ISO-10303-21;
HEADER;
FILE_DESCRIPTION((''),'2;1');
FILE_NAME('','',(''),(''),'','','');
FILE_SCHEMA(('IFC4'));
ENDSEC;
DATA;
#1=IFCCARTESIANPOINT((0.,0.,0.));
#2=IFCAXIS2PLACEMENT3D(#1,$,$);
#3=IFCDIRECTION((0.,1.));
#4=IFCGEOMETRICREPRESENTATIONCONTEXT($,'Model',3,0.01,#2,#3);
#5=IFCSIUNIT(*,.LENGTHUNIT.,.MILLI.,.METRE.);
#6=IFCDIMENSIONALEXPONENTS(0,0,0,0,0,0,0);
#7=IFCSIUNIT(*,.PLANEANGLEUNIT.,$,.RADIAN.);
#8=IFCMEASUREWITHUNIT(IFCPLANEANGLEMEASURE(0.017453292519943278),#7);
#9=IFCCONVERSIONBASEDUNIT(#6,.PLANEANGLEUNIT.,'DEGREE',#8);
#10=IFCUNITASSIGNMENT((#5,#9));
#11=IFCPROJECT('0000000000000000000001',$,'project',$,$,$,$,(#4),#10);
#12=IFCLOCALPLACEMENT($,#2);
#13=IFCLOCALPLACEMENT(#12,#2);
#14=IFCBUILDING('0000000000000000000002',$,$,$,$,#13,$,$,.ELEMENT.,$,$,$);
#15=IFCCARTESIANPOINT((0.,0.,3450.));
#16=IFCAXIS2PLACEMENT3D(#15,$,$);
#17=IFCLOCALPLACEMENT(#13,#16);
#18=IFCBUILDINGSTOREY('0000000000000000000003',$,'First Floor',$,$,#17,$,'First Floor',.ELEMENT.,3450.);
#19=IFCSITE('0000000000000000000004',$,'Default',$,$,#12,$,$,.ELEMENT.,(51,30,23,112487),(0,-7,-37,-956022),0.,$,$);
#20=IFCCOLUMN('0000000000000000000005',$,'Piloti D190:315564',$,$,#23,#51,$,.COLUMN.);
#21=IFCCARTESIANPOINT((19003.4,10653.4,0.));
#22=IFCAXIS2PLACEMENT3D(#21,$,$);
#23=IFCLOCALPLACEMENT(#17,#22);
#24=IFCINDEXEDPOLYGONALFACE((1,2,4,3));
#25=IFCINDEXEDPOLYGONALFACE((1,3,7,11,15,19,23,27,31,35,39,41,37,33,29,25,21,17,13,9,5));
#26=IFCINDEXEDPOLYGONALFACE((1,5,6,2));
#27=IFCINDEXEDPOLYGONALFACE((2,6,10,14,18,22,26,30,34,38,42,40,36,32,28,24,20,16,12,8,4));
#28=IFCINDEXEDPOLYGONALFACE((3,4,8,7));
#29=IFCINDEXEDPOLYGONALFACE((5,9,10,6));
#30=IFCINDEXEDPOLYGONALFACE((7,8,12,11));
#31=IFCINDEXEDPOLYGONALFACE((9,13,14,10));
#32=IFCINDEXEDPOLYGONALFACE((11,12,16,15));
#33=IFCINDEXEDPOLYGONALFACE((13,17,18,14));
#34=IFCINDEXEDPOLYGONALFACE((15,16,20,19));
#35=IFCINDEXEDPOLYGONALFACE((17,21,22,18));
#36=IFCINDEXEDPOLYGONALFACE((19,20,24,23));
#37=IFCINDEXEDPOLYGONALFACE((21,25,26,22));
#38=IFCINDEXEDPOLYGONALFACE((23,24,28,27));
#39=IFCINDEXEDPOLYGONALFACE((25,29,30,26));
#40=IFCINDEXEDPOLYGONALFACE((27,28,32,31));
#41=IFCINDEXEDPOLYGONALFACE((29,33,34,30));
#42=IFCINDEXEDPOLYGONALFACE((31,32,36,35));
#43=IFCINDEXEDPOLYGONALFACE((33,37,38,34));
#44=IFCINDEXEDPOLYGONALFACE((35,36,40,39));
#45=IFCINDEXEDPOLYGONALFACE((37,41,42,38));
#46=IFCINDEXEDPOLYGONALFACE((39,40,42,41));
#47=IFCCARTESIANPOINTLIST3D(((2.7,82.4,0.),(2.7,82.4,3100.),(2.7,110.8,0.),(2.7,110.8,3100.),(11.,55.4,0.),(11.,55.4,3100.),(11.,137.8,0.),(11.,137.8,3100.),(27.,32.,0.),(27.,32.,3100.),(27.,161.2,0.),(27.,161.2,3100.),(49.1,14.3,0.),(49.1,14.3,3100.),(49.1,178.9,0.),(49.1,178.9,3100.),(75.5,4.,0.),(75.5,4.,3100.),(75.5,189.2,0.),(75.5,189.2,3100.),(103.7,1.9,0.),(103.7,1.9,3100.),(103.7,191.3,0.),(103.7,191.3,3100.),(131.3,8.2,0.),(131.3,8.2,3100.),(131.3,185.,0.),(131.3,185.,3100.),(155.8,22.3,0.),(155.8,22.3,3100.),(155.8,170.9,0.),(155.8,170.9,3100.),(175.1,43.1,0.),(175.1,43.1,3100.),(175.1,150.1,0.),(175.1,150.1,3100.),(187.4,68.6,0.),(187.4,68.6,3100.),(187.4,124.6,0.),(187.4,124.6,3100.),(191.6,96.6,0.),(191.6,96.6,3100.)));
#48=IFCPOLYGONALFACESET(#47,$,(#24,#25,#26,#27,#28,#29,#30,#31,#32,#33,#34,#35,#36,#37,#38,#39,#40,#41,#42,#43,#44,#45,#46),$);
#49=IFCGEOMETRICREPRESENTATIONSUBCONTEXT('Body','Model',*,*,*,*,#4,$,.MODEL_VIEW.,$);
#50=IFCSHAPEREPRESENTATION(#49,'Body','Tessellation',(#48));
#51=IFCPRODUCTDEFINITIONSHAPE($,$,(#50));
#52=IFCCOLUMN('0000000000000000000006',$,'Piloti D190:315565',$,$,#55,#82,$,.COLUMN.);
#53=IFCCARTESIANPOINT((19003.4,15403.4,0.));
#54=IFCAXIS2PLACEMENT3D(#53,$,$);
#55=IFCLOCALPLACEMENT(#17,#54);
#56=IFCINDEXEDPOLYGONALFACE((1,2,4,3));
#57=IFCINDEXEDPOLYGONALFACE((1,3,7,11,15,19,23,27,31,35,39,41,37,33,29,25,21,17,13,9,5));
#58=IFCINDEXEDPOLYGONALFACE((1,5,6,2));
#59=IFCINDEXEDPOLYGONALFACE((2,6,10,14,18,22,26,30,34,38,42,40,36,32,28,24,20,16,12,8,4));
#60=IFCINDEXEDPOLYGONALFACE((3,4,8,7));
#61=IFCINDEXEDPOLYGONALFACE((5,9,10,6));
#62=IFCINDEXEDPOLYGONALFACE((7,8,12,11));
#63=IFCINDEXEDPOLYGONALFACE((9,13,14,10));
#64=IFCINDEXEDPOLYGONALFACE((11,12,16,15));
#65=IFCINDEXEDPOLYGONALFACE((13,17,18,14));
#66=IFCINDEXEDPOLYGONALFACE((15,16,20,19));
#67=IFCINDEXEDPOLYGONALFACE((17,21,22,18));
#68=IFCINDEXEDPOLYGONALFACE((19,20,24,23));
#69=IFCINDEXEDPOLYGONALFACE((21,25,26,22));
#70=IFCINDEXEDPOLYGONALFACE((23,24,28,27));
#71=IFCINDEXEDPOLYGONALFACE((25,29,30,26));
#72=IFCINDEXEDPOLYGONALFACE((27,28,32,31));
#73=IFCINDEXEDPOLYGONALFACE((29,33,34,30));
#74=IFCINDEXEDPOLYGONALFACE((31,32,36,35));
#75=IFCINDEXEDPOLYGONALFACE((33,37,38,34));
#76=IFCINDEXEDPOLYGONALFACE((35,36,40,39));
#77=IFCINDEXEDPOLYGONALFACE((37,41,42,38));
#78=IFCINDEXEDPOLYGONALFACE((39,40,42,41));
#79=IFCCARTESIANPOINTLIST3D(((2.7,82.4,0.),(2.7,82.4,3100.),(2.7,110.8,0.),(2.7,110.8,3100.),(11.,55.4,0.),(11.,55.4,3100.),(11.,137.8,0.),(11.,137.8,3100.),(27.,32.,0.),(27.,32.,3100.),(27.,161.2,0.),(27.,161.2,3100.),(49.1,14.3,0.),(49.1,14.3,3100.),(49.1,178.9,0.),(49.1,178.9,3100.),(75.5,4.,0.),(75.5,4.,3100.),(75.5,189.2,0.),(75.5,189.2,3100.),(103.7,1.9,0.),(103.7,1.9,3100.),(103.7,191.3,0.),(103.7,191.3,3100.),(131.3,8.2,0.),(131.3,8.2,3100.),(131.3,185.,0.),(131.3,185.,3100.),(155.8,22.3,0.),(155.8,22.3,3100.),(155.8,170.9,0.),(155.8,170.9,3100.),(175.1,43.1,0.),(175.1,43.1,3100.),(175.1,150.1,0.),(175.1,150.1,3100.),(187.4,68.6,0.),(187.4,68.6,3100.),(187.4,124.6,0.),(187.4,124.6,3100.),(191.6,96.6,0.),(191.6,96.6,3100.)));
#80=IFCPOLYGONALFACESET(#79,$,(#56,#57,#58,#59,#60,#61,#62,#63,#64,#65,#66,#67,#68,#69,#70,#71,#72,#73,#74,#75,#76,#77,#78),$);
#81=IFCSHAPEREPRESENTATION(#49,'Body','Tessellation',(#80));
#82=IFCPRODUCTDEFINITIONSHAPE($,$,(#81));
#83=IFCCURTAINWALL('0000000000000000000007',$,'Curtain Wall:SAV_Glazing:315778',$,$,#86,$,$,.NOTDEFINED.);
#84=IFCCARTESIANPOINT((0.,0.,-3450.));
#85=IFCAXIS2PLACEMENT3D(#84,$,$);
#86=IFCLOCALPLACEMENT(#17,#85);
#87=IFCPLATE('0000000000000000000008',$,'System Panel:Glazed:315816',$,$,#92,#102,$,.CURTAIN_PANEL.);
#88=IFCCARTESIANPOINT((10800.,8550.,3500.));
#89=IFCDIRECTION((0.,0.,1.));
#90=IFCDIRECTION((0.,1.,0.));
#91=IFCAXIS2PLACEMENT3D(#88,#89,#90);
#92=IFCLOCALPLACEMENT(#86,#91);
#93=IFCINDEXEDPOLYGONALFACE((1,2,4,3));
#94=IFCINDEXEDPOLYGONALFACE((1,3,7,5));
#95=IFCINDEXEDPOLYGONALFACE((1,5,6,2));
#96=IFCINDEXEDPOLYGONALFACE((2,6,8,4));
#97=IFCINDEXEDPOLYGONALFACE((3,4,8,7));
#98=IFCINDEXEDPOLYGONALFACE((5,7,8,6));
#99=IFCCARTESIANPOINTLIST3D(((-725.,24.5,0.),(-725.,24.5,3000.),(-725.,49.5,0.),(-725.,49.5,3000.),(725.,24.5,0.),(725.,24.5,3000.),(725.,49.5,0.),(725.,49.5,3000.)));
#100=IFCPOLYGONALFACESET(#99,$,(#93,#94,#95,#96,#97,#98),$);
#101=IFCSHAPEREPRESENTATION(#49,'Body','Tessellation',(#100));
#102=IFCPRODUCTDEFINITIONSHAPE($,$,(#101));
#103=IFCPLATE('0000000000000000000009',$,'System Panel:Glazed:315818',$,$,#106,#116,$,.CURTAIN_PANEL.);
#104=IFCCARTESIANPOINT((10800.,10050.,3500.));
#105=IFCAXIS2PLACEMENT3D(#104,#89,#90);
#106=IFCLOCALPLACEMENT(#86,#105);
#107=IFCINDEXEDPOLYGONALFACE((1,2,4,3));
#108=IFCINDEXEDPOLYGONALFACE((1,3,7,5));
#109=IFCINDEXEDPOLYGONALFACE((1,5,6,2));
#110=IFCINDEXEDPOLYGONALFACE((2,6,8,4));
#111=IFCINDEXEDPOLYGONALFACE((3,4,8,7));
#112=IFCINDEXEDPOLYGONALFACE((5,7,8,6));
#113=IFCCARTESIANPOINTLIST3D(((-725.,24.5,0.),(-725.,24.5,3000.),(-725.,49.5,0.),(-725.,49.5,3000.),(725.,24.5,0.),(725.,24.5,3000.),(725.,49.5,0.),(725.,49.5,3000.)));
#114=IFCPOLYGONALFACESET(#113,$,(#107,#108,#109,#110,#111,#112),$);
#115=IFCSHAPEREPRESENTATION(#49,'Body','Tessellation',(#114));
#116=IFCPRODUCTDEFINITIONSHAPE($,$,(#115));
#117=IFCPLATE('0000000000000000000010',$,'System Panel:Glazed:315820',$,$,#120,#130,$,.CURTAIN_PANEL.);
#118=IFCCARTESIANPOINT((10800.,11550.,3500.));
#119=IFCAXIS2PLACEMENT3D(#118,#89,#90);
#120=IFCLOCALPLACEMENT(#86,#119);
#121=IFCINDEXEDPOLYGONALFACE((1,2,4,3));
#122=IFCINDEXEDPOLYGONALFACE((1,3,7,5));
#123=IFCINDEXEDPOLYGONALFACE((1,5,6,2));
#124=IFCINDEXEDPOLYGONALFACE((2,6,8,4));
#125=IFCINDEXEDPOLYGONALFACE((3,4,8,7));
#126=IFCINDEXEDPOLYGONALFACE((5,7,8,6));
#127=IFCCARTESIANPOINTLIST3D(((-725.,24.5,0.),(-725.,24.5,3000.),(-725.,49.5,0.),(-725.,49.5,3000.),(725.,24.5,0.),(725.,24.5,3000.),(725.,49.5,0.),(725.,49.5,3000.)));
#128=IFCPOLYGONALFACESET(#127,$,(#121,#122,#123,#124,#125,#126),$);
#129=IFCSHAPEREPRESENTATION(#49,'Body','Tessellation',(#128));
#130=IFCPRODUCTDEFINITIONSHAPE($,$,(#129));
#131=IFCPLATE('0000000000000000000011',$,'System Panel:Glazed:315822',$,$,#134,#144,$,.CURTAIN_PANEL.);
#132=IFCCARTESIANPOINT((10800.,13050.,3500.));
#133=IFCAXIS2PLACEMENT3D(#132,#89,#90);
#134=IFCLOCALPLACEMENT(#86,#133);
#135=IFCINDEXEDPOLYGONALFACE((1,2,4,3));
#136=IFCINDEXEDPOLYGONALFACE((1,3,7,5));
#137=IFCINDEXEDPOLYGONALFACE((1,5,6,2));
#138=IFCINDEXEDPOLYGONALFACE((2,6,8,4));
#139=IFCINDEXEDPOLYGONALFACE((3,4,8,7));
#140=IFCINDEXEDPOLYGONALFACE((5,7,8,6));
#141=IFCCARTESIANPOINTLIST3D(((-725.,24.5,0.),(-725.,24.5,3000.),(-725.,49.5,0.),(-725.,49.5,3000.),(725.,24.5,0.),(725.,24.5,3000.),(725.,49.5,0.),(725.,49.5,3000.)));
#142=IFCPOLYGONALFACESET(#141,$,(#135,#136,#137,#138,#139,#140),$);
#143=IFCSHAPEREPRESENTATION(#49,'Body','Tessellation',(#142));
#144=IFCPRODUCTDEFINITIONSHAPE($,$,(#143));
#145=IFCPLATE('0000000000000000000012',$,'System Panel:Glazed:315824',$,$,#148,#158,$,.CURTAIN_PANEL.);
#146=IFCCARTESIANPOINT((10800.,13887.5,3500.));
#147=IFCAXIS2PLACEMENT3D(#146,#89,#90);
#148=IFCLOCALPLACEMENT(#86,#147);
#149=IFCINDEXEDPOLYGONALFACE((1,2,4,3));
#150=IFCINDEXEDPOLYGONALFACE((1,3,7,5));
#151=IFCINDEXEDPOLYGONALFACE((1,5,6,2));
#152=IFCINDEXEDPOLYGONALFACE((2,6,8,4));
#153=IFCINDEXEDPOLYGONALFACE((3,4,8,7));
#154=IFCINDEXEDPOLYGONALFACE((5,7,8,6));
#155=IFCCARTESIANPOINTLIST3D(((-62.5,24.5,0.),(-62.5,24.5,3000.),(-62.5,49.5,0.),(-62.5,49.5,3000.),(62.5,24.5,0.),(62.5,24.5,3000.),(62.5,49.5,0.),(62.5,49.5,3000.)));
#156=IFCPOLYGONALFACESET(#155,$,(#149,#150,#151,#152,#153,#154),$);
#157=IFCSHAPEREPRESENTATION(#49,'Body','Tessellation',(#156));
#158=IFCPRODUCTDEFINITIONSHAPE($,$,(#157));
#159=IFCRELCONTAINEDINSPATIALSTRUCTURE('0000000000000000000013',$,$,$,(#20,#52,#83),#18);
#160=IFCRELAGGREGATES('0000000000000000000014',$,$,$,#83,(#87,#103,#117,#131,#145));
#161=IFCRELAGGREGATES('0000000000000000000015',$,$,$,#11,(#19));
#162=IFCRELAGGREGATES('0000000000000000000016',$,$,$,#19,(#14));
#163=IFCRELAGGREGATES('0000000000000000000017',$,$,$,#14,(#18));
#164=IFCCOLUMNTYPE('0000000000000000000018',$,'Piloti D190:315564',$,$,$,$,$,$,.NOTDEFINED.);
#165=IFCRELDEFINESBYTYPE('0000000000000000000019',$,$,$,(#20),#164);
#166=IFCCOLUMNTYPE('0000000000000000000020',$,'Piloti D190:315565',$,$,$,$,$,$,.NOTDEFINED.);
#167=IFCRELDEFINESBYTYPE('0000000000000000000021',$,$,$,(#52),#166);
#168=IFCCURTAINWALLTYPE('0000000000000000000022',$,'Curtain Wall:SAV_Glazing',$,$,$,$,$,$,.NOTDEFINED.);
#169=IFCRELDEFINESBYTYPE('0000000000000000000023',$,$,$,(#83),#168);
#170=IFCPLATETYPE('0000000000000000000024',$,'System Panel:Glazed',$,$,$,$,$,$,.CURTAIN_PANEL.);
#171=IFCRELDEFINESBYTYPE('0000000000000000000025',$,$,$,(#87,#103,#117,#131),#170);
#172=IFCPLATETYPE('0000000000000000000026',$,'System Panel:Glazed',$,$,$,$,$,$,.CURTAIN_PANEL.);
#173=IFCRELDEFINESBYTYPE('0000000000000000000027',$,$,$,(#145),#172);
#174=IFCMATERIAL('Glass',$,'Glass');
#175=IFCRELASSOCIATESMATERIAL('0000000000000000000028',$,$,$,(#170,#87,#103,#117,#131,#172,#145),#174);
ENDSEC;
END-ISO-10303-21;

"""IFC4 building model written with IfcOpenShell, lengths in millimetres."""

from ifc_helpers import new_model, entity, si_unit, converted_unit, direction, frame, frame_2d, origin, origin_2d_with_axis, place, context, subcontext, project, spatial, rectangle, circle, extrude, source, transform, mapped, material, type_object, type_shapes, element, aggregate, save


model = new_model("IFC4")

# Units and contexts
model_context = context("Model", 3, precision=0.01, world=origin(), true_north=direction((0.0, 1.0)))
body_context = subcontext(model_context, "Body", "Model", "MODEL_VIEW")
ifc_project = project(units=[si_unit("LENGTHUNIT", "METRE", prefix="MILLI"), converted_unit("PLANEANGLEUNIT", "DEGREE", entity("IfcPlaneAngleMeasure", 0.017453292519943278), si_unit("PLANEANGLEUNIT", "RADIAN"), dimensions=[0, 0, 0, 0, 0, 0, 0])], contexts=[model_context])

# Site, building, storey
site_placement = place(None, origin())
site = spatial("IfcSite", under=ifc_project, at=site_placement, Name="Default", CompositionType="ELEMENT", RefLatitude=(51, 30, 23, 112487), RefLongitude=(0, -7, -37, -956022), RefElevation=0.0)
building_placement = place(site_placement, origin())
building = spatial("IfcBuilding", under=site, at=building_placement, CompositionType="ELEMENT")
storey_placement = place(building_placement, frame((0.0, 0.0, 3450.0)))
storey = spatial("IfcBuildingStorey", under=building, at=storey_placement, Name="First Floor", LongName="First Floor", CompositionType="ELEMENT", Elevation=3450.0)

# Columns
column_type_1 = type_object("IfcColumnType", Name="Piloti D190:315564", PredefinedType="NOTDEFINED")
column_1_placement = place(storey_placement, frame((19003.4, 10653.4, 0.0)))
element("IfcColumn", 1, at=column_1_placement, inside=storey, type_object=column_type_1, Name="Piloti D190:315564", PredefinedType="COLUMN", context=body_context, shape_type="SweptSolid", body=[
    extrude(circle(Radius=95.0, at=origin_2d_with_axis()), frame((96.6, 96.6, 0.0)), (0.0, 0.0, 1.0), 3100.0),
])
column_type_2 = type_object("IfcColumnType", Name="Piloti D190:315565", PredefinedType="NOTDEFINED")
column_2_placement = place(storey_placement, frame((19003.4, 15403.4, 0.0)))
element("IfcColumn", 2, at=column_2_placement, inside=storey, type_object=column_type_2, Name="Piloti D190:315565", PredefinedType="COLUMN", context=body_context, shape_type="SweptSolid", body=[
    extrude(circle(Radius=95.0, at=origin_2d_with_axis()), frame((96.6, 96.6, 0.0)), (0.0, 0.0, 1.0), 3100.0),
])

# Curtain wall, plates
curtain_wall_type = type_object("IfcCurtainWallType", Name="Curtain Wall:SAV_Glazing", PredefinedType="NOTDEFINED")
curtain_wall_placement = place(storey_placement, frame((0.0, 0.0, -3450.0)))
curtain_wall = element("IfcCurtainWall", 3, at=curtain_wall_placement, inside=storey, type_object=curtain_wall_type, Name="Curtain Wall:SAV_Glazing:315778", PredefinedType="NOTDEFINED")
ifc_material_1 = material(Name="Glass", Category="Glass")
plate_type_1 = type_object("IfcPlateType", Name="System Panel:Glazed", PredefinedType="CURTAIN_PANEL", material=ifc_material_1)
shared_shape_1 = source(origin(), body_context, "Body", "SweptSolid", [
    extrude(rectangle(XDim=25.0, YDim=1450.0, at=frame_2d((0.0, 0.0), x_axis=(1.0, 0.0))), frame((0.0, 37.0, 0.0), z_axis=(0.0, 0.0, 1.0), x_axis=(0.0, 1.0, 0.0)), (0.0, 0.0, 1.0), 3000.0),
])
type_shapes(plate_type_1, [shared_shape_1])
plate_1_placement = place(curtain_wall_placement, frame((10800.0, 8550.0, 3500.0), z_axis=(0.0, 0.0, 1.0), x_axis=(0.0, 1.0, 0.0)))
plate_1 = element("IfcPlate", 4, at=plate_1_placement, type_object=plate_type_1, material=ifc_material_1, Name="System Panel:Glazed:315816", PredefinedType="CURTAIN_PANEL", context=body_context, shape_type="MappedRepresentation", body=[
    mapped(shared_shape_1, transform((0.0, 0.0, 0.0), scale=1.0)),
])
plate_2_placement = place(curtain_wall_placement, frame((10800.0, 10050.0, 3500.0), z_axis=(0.0, 0.0, 1.0), x_axis=(0.0, 1.0, 0.0)))
plate_2 = element("IfcPlate", 5, at=plate_2_placement, type_object=plate_type_1, material=ifc_material_1, Name="System Panel:Glazed:315818", PredefinedType="CURTAIN_PANEL", context=body_context, shape_type="MappedRepresentation", body=[
    mapped(shared_shape_1, transform((0.0, 0.0, 0.0), scale=1.0)),
])
plate_3_placement = place(curtain_wall_placement, frame((10800.0, 11550.0, 3500.0), z_axis=(0.0, 0.0, 1.0), x_axis=(0.0, 1.0, 0.0)))
plate_3 = element("IfcPlate", 6, at=plate_3_placement, type_object=plate_type_1, material=ifc_material_1, Name="System Panel:Glazed:315820", PredefinedType="CURTAIN_PANEL", context=body_context, shape_type="MappedRepresentation", body=[
    mapped(shared_shape_1, transform((0.0, 0.0, 0.0), scale=1.0)),
])
plate_4_placement = place(curtain_wall_placement, frame((10800.0, 13050.0, 3500.0), z_axis=(0.0, 0.0, 1.0), x_axis=(0.0, 1.0, 0.0)))
plate_4 = element("IfcPlate", 7, at=plate_4_placement, type_object=plate_type_1, material=ifc_material_1, Name="System Panel:Glazed:315822", PredefinedType="CURTAIN_PANEL", context=body_context, shape_type="MappedRepresentation", body=[
    mapped(shared_shape_1, transform((0.0, 0.0, 0.0), scale=1.0)),
])
plate_type_2 = type_object("IfcPlateType", Name="System Panel:Glazed", PredefinedType="CURTAIN_PANEL", material=ifc_material_1)
shared_shape_2 = source(origin(), body_context, "Body", "SweptSolid", [
    extrude(rectangle(XDim=25.0, YDim=125.0, at=origin_2d_with_axis()), frame((0.0, 37.0, 0.0), z_axis=(0.0, 0.0, 1.0), x_axis=(0.0, 1.0, 0.0)), (0.0, 0.0, 1.0), 3000.0),
])
type_shapes(plate_type_2, [shared_shape_2])
plate_5_placement = place(curtain_wall_placement, frame((10800.0, 13887.5, 3500.0), z_axis=(0.0, 0.0, 1.0), x_axis=(0.0, 1.0, 0.0)))
plate_5 = element("IfcPlate", 8, at=plate_5_placement, type_object=plate_type_2, material=ifc_material_1, Name="System Panel:Glazed:315824", PredefinedType="CURTAIN_PANEL", context=body_context, shape_type="MappedRepresentation", body=[
    mapped(shared_shape_2, transform((0.0, 0.0, 0.0), scale=1.0)),
])
aggregate(curtain_wall, [plate_1, plate_2, plate_3, plate_4, plate_5])

save(model, "model.ifc")
